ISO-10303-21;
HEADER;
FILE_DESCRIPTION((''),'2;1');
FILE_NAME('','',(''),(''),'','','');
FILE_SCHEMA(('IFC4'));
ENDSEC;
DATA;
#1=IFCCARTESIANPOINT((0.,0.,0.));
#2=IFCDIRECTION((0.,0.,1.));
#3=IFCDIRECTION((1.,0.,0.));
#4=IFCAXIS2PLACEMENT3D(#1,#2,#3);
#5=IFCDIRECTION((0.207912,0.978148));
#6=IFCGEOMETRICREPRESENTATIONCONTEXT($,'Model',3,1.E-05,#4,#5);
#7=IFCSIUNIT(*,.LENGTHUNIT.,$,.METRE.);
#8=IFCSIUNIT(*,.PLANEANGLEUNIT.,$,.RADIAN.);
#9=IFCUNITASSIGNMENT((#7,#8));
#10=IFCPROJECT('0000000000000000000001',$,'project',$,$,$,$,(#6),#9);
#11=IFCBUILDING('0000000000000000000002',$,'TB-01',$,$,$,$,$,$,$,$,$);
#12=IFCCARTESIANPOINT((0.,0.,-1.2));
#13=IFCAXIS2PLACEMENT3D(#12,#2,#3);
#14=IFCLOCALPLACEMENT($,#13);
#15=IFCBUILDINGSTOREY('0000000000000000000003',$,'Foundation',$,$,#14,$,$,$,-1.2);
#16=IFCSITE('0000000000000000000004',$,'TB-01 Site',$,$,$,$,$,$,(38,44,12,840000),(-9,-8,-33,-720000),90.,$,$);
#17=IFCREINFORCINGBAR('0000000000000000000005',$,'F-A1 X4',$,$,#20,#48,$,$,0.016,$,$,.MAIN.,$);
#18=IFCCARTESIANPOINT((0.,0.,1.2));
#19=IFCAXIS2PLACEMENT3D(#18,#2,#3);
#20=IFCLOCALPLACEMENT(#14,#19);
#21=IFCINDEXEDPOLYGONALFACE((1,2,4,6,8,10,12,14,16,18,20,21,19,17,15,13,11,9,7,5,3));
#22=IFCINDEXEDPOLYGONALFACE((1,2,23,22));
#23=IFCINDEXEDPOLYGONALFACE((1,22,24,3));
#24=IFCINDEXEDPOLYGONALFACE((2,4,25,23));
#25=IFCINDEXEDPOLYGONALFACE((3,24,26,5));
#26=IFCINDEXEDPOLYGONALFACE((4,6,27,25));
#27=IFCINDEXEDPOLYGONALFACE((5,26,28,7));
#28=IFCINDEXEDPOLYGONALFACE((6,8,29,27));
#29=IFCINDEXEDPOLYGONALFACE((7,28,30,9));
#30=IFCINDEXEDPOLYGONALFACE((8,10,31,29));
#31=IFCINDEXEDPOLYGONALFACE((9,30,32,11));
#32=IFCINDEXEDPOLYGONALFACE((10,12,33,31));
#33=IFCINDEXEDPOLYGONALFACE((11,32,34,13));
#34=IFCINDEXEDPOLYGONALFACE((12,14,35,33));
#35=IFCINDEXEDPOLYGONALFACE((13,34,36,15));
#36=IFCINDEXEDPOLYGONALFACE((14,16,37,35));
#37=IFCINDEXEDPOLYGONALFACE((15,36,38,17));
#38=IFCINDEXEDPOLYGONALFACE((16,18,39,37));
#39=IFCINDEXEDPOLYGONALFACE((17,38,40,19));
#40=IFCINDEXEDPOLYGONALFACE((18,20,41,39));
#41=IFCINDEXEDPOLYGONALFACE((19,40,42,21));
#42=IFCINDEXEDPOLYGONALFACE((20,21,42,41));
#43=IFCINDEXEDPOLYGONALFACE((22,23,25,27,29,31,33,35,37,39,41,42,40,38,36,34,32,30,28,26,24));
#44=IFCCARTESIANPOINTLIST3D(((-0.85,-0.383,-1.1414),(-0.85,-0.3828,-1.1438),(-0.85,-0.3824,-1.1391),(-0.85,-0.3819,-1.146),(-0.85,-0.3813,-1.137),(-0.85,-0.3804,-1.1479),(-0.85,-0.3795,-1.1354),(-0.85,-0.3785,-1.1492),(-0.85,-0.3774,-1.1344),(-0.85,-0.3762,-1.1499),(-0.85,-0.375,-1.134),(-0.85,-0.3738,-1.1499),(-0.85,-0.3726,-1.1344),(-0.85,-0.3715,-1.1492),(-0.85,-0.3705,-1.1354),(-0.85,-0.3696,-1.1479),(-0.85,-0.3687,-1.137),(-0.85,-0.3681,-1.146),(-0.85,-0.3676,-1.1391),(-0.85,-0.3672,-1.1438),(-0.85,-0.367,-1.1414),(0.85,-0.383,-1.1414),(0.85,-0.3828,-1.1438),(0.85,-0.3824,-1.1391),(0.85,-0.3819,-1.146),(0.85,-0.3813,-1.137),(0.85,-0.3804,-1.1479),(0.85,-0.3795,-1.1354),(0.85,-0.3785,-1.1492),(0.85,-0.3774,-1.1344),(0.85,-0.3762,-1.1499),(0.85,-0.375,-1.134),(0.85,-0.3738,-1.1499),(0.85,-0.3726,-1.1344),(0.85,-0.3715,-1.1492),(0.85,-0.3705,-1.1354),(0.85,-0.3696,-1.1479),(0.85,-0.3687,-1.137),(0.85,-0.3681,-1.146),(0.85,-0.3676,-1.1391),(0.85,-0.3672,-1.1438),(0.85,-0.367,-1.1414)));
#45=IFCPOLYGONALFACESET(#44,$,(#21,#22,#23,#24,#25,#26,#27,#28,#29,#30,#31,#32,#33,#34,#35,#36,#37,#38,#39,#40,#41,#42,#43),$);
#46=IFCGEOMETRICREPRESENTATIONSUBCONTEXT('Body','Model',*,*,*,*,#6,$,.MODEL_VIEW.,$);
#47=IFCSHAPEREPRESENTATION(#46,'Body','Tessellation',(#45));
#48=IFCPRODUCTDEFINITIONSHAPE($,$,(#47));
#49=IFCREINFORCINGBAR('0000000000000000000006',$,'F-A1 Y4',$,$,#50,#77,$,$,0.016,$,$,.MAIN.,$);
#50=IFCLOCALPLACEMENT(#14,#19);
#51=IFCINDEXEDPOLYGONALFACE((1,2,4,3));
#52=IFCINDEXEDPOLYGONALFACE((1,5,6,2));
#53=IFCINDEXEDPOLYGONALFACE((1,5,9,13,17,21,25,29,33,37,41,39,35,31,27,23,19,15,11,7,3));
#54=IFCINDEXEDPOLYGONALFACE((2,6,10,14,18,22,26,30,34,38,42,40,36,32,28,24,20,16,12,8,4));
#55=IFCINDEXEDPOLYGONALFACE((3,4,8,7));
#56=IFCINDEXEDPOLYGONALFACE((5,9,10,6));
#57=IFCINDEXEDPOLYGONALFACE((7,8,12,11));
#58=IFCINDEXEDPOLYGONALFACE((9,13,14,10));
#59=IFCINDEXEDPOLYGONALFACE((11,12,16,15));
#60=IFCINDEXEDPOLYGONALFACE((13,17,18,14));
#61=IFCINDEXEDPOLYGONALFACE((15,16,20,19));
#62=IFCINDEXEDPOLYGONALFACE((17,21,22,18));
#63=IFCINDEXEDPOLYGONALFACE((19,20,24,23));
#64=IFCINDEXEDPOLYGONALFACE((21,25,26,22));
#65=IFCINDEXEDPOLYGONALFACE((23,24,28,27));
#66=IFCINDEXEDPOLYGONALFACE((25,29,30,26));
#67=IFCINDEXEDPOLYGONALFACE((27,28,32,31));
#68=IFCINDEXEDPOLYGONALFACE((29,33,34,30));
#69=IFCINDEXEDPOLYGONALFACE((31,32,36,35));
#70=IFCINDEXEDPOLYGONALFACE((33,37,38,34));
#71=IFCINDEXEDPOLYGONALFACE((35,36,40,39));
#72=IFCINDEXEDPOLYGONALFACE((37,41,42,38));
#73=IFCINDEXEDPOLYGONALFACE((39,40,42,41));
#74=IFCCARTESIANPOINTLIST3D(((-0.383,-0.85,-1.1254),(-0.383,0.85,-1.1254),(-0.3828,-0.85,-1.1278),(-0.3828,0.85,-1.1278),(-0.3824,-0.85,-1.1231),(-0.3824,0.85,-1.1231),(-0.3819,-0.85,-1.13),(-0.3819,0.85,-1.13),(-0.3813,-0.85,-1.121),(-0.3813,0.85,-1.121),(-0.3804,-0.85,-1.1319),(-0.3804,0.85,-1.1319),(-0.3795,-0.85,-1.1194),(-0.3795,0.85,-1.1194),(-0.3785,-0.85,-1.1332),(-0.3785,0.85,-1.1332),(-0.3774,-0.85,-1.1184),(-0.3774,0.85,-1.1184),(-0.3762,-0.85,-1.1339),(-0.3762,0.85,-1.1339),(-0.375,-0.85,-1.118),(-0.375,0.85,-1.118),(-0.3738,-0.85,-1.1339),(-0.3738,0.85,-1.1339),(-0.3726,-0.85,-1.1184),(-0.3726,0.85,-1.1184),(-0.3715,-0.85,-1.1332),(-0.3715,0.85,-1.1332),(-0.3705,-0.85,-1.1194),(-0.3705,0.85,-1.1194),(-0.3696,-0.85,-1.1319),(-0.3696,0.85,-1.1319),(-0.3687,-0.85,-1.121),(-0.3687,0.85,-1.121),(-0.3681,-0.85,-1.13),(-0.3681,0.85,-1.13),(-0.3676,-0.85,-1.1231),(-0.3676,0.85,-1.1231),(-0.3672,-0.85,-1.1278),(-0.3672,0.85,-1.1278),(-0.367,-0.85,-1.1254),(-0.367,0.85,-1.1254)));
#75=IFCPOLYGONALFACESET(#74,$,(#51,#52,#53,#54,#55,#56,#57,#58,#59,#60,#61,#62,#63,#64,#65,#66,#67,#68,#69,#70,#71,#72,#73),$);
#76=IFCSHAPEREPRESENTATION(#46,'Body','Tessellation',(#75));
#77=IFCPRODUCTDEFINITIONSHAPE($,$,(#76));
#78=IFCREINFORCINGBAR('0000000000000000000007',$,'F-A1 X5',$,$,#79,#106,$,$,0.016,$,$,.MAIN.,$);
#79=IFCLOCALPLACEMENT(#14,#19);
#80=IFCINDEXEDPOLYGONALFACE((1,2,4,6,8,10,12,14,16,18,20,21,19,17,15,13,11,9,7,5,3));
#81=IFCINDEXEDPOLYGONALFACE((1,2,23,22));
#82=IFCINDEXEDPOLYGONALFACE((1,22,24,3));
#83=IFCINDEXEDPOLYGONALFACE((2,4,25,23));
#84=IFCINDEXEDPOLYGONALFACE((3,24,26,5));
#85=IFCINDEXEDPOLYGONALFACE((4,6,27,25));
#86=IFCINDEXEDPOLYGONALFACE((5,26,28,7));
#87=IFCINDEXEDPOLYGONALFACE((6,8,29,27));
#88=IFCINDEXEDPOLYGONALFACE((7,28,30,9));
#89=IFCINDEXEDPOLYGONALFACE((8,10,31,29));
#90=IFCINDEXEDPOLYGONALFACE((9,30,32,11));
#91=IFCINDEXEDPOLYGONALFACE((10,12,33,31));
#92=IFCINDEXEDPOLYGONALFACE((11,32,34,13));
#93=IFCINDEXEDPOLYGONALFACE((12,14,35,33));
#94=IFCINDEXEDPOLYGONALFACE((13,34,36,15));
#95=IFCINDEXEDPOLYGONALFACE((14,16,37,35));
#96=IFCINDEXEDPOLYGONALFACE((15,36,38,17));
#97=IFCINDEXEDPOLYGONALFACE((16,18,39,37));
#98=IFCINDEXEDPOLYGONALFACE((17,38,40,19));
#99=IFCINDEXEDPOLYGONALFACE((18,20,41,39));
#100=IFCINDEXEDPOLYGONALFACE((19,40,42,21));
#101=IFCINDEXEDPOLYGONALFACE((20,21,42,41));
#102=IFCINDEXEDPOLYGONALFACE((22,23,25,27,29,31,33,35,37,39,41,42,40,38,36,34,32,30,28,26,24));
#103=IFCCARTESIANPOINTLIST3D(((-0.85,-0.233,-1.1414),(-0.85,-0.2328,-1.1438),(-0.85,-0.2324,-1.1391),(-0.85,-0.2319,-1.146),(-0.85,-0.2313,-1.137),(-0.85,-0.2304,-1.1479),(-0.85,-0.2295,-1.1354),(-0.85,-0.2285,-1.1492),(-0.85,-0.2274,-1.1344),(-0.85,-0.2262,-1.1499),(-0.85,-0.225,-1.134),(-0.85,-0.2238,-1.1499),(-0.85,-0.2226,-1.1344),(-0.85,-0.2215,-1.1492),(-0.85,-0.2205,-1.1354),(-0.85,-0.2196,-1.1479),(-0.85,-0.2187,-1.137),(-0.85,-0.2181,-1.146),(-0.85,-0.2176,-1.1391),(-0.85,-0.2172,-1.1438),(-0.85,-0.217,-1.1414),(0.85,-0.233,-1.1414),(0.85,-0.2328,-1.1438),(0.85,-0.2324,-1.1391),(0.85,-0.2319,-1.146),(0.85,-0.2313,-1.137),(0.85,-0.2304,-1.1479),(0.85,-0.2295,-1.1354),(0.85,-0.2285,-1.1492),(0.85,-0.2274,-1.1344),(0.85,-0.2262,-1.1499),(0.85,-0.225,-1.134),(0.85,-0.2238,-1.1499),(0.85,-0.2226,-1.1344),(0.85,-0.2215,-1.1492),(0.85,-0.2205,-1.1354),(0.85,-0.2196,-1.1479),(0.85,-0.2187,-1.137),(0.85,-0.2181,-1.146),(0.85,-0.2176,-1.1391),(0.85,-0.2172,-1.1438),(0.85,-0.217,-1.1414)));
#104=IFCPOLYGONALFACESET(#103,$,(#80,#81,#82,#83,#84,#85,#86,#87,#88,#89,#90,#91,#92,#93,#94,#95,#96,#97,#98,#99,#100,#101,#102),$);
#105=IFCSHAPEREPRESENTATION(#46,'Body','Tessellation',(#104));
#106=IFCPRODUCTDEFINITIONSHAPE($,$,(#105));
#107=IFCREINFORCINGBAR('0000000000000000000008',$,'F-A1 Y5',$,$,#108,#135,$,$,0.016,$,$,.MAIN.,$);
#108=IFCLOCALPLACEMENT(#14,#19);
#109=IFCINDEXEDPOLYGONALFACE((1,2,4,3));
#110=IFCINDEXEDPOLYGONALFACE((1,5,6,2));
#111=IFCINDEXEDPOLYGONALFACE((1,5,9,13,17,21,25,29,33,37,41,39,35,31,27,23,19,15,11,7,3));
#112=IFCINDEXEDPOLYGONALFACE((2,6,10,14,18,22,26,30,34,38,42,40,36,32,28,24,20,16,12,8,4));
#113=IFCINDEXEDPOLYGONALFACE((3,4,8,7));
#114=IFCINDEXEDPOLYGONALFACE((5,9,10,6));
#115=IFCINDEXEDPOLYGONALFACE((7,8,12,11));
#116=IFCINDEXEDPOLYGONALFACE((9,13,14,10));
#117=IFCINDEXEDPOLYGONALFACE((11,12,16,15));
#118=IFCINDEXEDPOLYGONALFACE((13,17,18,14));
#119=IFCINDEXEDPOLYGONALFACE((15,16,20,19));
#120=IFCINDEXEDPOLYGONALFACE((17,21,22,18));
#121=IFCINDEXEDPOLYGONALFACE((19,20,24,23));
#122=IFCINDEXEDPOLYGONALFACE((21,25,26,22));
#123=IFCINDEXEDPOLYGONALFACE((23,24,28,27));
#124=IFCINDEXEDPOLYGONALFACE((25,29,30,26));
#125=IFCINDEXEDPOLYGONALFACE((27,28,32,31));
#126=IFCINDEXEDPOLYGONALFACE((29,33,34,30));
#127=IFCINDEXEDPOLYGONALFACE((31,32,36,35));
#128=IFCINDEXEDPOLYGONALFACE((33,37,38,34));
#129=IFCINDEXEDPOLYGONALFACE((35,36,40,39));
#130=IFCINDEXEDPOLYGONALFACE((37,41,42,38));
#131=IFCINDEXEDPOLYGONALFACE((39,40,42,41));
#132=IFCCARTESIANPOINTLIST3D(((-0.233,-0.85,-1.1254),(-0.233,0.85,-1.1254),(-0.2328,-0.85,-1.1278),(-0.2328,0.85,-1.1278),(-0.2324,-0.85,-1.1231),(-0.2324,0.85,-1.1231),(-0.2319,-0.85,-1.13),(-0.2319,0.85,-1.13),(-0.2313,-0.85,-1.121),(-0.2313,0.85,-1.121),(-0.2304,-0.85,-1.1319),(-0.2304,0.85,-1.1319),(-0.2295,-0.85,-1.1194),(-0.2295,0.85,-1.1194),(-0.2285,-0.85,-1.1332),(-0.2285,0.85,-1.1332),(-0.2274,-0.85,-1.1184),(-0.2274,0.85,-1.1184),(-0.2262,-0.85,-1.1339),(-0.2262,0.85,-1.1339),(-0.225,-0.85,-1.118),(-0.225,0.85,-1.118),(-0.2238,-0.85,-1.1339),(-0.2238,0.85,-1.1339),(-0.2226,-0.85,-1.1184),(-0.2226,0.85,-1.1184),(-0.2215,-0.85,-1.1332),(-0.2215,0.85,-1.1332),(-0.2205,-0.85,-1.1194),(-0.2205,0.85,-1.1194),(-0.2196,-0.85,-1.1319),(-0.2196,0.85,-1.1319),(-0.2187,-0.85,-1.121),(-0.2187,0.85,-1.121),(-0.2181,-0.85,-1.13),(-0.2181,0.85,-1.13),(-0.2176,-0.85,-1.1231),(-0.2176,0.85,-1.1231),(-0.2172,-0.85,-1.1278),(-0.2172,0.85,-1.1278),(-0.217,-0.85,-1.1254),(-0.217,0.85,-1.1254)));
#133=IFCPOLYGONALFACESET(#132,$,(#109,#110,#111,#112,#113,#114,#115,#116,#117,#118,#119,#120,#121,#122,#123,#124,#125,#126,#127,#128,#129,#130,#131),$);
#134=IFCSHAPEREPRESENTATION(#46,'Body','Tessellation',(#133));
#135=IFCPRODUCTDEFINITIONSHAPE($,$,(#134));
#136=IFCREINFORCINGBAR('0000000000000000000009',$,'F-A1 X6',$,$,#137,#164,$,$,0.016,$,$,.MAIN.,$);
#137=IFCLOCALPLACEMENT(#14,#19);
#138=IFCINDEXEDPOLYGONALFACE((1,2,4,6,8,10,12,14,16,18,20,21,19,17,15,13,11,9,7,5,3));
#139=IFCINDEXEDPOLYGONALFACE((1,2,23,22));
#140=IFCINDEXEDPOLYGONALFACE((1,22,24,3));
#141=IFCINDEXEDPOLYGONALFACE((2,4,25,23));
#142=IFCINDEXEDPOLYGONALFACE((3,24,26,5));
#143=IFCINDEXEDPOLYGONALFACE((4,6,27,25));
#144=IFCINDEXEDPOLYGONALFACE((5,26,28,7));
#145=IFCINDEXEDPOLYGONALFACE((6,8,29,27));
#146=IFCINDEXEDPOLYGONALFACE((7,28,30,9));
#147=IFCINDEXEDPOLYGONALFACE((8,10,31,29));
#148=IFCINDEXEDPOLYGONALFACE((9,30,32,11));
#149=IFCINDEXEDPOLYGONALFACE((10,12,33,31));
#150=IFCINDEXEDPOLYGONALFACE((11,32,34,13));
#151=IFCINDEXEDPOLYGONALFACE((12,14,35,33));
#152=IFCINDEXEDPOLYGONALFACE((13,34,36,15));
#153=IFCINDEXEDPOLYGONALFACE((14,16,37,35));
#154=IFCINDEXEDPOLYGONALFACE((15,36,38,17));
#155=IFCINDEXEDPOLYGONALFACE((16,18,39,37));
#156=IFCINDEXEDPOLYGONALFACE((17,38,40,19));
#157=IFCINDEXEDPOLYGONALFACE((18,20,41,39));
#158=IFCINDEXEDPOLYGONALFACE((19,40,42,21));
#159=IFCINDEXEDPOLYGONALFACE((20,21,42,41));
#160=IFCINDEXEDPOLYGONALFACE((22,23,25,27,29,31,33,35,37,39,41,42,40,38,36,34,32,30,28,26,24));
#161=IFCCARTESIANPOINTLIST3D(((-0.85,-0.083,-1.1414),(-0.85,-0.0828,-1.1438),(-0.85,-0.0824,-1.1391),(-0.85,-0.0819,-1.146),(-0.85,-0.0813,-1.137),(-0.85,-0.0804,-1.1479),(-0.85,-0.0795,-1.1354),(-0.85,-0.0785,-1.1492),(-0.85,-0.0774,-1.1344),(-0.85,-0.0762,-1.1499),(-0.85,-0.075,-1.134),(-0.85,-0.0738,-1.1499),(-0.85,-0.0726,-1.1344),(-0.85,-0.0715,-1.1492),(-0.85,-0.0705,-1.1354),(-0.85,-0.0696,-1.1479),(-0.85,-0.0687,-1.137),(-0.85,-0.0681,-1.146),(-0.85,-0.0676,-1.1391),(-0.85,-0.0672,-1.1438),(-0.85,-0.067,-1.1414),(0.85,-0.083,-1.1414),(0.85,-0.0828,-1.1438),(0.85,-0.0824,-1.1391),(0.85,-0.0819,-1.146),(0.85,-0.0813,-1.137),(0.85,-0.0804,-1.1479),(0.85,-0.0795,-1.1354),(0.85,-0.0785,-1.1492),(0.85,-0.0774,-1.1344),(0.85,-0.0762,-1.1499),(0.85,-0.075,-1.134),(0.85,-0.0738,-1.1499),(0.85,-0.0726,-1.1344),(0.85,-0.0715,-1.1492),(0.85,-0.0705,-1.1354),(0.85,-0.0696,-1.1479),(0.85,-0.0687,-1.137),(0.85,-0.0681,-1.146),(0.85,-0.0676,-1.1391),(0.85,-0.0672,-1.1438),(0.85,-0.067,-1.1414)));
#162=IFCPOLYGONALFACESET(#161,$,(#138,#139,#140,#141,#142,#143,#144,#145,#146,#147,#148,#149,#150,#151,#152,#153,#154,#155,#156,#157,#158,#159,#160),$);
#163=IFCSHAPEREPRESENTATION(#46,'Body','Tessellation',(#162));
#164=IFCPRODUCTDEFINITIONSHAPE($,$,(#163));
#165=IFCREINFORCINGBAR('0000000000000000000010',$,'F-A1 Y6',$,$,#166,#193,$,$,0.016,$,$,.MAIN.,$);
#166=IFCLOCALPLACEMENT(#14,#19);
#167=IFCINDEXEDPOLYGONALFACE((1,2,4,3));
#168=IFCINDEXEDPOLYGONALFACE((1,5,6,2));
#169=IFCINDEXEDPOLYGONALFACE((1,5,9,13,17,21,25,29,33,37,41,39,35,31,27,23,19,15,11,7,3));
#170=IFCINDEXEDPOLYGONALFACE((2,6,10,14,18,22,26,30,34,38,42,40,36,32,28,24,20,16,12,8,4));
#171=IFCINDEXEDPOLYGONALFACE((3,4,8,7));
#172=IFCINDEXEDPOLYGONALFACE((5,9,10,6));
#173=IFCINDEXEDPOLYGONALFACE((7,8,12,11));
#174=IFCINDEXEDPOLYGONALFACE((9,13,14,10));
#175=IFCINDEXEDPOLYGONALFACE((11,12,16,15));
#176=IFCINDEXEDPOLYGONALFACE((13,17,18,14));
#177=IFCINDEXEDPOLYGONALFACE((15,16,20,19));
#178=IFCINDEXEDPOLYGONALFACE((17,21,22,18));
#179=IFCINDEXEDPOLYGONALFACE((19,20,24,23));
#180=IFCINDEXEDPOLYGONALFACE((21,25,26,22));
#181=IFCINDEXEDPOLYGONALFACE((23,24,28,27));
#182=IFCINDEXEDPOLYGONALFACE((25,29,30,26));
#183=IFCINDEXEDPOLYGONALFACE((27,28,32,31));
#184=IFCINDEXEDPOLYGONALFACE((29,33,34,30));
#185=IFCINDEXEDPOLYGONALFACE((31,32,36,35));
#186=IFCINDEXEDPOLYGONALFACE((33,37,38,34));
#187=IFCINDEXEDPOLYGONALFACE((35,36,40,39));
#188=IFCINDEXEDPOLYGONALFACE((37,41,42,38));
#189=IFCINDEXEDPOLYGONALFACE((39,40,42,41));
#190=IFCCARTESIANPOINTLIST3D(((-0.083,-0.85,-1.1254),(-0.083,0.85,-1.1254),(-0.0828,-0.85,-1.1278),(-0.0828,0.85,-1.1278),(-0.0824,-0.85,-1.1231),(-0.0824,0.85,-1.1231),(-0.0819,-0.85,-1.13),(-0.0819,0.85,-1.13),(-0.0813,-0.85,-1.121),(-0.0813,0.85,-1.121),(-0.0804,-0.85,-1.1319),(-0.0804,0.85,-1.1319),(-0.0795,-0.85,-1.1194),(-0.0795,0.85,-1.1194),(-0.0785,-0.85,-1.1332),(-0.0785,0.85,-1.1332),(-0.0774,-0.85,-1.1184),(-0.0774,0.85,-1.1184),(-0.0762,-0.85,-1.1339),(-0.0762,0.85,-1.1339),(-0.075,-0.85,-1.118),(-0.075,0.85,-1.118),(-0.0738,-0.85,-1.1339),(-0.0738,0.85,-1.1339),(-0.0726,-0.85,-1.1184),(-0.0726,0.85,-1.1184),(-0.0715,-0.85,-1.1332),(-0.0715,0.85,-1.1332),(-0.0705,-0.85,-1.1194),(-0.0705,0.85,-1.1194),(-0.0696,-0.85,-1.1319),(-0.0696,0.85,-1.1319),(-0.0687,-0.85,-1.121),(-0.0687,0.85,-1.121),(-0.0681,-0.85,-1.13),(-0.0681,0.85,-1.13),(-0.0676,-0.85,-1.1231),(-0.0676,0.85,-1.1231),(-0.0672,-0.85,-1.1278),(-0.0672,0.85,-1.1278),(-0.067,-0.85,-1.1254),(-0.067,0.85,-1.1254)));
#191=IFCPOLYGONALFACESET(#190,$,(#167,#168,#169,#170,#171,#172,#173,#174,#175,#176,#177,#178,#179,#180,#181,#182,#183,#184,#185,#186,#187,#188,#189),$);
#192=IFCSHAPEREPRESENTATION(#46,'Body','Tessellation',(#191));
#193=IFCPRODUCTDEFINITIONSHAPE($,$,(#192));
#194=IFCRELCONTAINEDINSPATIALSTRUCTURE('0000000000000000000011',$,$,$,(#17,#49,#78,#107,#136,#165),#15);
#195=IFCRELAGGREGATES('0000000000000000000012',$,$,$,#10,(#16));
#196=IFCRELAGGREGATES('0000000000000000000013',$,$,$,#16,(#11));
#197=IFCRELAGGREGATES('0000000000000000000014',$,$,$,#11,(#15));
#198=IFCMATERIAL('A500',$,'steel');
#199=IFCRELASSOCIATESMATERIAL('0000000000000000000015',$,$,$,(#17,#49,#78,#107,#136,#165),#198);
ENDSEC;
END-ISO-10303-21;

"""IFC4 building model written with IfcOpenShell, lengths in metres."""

from ifc_helpers import new_model, entity, si_unit, direction, frame, origin_with_axes, place, context, subcontext, project, spatial, material, element, save


model = new_model("IFC4")

# Units and contexts
model_context = context("Model", 3, precision=1e-05, world=origin_with_axes(), true_north=direction((0.207912, 0.978148)))
body_context = subcontext(model_context, "Body", "Model", "MODEL_VIEW")
ifc_project = project(units=[si_unit("LENGTHUNIT", "METRE"), si_unit("PLANEANGLEUNIT", "RADIAN")], contexts=[model_context])

# Site, building, storey
site = spatial("IfcSite", under=ifc_project, Name="TB-01 Site", RefLatitude=(38, 44, 12, 840000), RefLongitude=(-9, -8, -33, -720000), RefElevation=90.0)
building = spatial("IfcBuilding", under=site, Name="TB-01")
storey_placement = place(None, frame((0.0, 0.0, -1.2), z_axis=(0.0, 0.0, 1.0), x_axis=(1.0, 0.0, 0.0)))
storey = spatial("IfcBuildingStorey", under=building, at=storey_placement, Name="Foundation", Elevation=-1.2)

# Reinforcing bars
ifc_material_1 = material(Name="A500", Category="steel")
reinforcing_bar_1_placement = place(storey_placement, frame((0.0, 0.0, 1.2), z_axis=(0.0, 0.0, 1.0), x_axis=(1.0, 0.0, 0.0)))
element("IfcReinforcingBar", 1, at=reinforcing_bar_1_placement, inside=storey, material=ifc_material_1, Name="F-A1 X4", NominalDiameter=0.016, PredefinedType="MAIN", context=body_context, shape_type="AdvancedSweptSolid", body=[
    entity("IfcSweptDiskSolid", entity("IfcPolyline", [entity("IfcCartesianPoint", [-0.85, -0.375, -1.142]), entity("IfcCartesianPoint", [0.85, -0.375, -1.142])]), 0.008),
])
reinforcing_bar_2_placement = place(storey_placement, frame((0.0, 0.0, 1.2), z_axis=(0.0, 0.0, 1.0), x_axis=(1.0, 0.0, 0.0)))
element("IfcReinforcingBar", 2, at=reinforcing_bar_2_placement, inside=storey, material=ifc_material_1, Name="F-A1 Y4", NominalDiameter=0.016, PredefinedType="MAIN", context=body_context, shape_type="AdvancedSweptSolid", body=[
    entity("IfcSweptDiskSolid", entity("IfcPolyline", [entity("IfcCartesianPoint", [-0.375, -0.85, -1.126]), entity("IfcCartesianPoint", [-0.375, 0.85, -1.126])]), 0.008),
])
reinforcing_bar_3_placement = place(storey_placement, frame((0.0, 0.0, 1.2), z_axis=(0.0, 0.0, 1.0), x_axis=(1.0, 0.0, 0.0)))
element("IfcReinforcingBar", 3, at=reinforcing_bar_3_placement, inside=storey, material=ifc_material_1, Name="F-A1 X5", NominalDiameter=0.016, PredefinedType="MAIN", context=body_context, shape_type="AdvancedSweptSolid", body=[
    entity("IfcSweptDiskSolid", entity("IfcPolyline", [entity("IfcCartesianPoint", [-0.85, -0.225, -1.142]), entity("IfcCartesianPoint", [0.85, -0.225, -1.142])]), 0.008),
])
reinforcing_bar_4_placement = place(storey_placement, frame((0.0, 0.0, 1.2), z_axis=(0.0, 0.0, 1.0), x_axis=(1.0, 0.0, 0.0)))
element("IfcReinforcingBar", 4, at=reinforcing_bar_4_placement, inside=storey, material=ifc_material_1, Name="F-A1 Y5", NominalDiameter=0.016, PredefinedType="MAIN", context=body_context, shape_type="AdvancedSweptSolid", body=[
    entity("IfcSweptDiskSolid", entity("IfcPolyline", [entity("IfcCartesianPoint", [-0.225, -0.85, -1.126]), entity("IfcCartesianPoint", [-0.225, 0.85, -1.126])]), 0.008),
])
reinforcing_bar_5_placement = place(storey_placement, frame((0.0, 0.0, 1.2), z_axis=(0.0, 0.0, 1.0), x_axis=(1.0, 0.0, 0.0)))
element("IfcReinforcingBar", 5, at=reinforcing_bar_5_placement, inside=storey, material=ifc_material_1, Name="F-A1 X6", NominalDiameter=0.016, PredefinedType="MAIN", context=body_context, shape_type="AdvancedSweptSolid", body=[
    entity("IfcSweptDiskSolid", entity("IfcPolyline", [entity("IfcCartesianPoint", [-0.85, -0.075, -1.142]), entity("IfcCartesianPoint", [0.85, -0.075, -1.142])]), 0.008),
])
reinforcing_bar_6_placement = place(storey_placement, frame((0.0, 0.0, 1.2), z_axis=(0.0, 0.0, 1.0), x_axis=(1.0, 0.0, 0.0)))
element("IfcReinforcingBar", 6, at=reinforcing_bar_6_placement, inside=storey, material=ifc_material_1, Name="F-A1 Y6", NominalDiameter=0.016, PredefinedType="MAIN", context=body_context, shape_type="AdvancedSweptSolid", body=[
    entity("IfcSweptDiskSolid", entity("IfcPolyline", [entity("IfcCartesianPoint", [-0.075, -0.85, -1.126]), entity("IfcCartesianPoint", [-0.075, 0.85, -1.126])]), 0.008),
])

save(model, "model.ifc")
